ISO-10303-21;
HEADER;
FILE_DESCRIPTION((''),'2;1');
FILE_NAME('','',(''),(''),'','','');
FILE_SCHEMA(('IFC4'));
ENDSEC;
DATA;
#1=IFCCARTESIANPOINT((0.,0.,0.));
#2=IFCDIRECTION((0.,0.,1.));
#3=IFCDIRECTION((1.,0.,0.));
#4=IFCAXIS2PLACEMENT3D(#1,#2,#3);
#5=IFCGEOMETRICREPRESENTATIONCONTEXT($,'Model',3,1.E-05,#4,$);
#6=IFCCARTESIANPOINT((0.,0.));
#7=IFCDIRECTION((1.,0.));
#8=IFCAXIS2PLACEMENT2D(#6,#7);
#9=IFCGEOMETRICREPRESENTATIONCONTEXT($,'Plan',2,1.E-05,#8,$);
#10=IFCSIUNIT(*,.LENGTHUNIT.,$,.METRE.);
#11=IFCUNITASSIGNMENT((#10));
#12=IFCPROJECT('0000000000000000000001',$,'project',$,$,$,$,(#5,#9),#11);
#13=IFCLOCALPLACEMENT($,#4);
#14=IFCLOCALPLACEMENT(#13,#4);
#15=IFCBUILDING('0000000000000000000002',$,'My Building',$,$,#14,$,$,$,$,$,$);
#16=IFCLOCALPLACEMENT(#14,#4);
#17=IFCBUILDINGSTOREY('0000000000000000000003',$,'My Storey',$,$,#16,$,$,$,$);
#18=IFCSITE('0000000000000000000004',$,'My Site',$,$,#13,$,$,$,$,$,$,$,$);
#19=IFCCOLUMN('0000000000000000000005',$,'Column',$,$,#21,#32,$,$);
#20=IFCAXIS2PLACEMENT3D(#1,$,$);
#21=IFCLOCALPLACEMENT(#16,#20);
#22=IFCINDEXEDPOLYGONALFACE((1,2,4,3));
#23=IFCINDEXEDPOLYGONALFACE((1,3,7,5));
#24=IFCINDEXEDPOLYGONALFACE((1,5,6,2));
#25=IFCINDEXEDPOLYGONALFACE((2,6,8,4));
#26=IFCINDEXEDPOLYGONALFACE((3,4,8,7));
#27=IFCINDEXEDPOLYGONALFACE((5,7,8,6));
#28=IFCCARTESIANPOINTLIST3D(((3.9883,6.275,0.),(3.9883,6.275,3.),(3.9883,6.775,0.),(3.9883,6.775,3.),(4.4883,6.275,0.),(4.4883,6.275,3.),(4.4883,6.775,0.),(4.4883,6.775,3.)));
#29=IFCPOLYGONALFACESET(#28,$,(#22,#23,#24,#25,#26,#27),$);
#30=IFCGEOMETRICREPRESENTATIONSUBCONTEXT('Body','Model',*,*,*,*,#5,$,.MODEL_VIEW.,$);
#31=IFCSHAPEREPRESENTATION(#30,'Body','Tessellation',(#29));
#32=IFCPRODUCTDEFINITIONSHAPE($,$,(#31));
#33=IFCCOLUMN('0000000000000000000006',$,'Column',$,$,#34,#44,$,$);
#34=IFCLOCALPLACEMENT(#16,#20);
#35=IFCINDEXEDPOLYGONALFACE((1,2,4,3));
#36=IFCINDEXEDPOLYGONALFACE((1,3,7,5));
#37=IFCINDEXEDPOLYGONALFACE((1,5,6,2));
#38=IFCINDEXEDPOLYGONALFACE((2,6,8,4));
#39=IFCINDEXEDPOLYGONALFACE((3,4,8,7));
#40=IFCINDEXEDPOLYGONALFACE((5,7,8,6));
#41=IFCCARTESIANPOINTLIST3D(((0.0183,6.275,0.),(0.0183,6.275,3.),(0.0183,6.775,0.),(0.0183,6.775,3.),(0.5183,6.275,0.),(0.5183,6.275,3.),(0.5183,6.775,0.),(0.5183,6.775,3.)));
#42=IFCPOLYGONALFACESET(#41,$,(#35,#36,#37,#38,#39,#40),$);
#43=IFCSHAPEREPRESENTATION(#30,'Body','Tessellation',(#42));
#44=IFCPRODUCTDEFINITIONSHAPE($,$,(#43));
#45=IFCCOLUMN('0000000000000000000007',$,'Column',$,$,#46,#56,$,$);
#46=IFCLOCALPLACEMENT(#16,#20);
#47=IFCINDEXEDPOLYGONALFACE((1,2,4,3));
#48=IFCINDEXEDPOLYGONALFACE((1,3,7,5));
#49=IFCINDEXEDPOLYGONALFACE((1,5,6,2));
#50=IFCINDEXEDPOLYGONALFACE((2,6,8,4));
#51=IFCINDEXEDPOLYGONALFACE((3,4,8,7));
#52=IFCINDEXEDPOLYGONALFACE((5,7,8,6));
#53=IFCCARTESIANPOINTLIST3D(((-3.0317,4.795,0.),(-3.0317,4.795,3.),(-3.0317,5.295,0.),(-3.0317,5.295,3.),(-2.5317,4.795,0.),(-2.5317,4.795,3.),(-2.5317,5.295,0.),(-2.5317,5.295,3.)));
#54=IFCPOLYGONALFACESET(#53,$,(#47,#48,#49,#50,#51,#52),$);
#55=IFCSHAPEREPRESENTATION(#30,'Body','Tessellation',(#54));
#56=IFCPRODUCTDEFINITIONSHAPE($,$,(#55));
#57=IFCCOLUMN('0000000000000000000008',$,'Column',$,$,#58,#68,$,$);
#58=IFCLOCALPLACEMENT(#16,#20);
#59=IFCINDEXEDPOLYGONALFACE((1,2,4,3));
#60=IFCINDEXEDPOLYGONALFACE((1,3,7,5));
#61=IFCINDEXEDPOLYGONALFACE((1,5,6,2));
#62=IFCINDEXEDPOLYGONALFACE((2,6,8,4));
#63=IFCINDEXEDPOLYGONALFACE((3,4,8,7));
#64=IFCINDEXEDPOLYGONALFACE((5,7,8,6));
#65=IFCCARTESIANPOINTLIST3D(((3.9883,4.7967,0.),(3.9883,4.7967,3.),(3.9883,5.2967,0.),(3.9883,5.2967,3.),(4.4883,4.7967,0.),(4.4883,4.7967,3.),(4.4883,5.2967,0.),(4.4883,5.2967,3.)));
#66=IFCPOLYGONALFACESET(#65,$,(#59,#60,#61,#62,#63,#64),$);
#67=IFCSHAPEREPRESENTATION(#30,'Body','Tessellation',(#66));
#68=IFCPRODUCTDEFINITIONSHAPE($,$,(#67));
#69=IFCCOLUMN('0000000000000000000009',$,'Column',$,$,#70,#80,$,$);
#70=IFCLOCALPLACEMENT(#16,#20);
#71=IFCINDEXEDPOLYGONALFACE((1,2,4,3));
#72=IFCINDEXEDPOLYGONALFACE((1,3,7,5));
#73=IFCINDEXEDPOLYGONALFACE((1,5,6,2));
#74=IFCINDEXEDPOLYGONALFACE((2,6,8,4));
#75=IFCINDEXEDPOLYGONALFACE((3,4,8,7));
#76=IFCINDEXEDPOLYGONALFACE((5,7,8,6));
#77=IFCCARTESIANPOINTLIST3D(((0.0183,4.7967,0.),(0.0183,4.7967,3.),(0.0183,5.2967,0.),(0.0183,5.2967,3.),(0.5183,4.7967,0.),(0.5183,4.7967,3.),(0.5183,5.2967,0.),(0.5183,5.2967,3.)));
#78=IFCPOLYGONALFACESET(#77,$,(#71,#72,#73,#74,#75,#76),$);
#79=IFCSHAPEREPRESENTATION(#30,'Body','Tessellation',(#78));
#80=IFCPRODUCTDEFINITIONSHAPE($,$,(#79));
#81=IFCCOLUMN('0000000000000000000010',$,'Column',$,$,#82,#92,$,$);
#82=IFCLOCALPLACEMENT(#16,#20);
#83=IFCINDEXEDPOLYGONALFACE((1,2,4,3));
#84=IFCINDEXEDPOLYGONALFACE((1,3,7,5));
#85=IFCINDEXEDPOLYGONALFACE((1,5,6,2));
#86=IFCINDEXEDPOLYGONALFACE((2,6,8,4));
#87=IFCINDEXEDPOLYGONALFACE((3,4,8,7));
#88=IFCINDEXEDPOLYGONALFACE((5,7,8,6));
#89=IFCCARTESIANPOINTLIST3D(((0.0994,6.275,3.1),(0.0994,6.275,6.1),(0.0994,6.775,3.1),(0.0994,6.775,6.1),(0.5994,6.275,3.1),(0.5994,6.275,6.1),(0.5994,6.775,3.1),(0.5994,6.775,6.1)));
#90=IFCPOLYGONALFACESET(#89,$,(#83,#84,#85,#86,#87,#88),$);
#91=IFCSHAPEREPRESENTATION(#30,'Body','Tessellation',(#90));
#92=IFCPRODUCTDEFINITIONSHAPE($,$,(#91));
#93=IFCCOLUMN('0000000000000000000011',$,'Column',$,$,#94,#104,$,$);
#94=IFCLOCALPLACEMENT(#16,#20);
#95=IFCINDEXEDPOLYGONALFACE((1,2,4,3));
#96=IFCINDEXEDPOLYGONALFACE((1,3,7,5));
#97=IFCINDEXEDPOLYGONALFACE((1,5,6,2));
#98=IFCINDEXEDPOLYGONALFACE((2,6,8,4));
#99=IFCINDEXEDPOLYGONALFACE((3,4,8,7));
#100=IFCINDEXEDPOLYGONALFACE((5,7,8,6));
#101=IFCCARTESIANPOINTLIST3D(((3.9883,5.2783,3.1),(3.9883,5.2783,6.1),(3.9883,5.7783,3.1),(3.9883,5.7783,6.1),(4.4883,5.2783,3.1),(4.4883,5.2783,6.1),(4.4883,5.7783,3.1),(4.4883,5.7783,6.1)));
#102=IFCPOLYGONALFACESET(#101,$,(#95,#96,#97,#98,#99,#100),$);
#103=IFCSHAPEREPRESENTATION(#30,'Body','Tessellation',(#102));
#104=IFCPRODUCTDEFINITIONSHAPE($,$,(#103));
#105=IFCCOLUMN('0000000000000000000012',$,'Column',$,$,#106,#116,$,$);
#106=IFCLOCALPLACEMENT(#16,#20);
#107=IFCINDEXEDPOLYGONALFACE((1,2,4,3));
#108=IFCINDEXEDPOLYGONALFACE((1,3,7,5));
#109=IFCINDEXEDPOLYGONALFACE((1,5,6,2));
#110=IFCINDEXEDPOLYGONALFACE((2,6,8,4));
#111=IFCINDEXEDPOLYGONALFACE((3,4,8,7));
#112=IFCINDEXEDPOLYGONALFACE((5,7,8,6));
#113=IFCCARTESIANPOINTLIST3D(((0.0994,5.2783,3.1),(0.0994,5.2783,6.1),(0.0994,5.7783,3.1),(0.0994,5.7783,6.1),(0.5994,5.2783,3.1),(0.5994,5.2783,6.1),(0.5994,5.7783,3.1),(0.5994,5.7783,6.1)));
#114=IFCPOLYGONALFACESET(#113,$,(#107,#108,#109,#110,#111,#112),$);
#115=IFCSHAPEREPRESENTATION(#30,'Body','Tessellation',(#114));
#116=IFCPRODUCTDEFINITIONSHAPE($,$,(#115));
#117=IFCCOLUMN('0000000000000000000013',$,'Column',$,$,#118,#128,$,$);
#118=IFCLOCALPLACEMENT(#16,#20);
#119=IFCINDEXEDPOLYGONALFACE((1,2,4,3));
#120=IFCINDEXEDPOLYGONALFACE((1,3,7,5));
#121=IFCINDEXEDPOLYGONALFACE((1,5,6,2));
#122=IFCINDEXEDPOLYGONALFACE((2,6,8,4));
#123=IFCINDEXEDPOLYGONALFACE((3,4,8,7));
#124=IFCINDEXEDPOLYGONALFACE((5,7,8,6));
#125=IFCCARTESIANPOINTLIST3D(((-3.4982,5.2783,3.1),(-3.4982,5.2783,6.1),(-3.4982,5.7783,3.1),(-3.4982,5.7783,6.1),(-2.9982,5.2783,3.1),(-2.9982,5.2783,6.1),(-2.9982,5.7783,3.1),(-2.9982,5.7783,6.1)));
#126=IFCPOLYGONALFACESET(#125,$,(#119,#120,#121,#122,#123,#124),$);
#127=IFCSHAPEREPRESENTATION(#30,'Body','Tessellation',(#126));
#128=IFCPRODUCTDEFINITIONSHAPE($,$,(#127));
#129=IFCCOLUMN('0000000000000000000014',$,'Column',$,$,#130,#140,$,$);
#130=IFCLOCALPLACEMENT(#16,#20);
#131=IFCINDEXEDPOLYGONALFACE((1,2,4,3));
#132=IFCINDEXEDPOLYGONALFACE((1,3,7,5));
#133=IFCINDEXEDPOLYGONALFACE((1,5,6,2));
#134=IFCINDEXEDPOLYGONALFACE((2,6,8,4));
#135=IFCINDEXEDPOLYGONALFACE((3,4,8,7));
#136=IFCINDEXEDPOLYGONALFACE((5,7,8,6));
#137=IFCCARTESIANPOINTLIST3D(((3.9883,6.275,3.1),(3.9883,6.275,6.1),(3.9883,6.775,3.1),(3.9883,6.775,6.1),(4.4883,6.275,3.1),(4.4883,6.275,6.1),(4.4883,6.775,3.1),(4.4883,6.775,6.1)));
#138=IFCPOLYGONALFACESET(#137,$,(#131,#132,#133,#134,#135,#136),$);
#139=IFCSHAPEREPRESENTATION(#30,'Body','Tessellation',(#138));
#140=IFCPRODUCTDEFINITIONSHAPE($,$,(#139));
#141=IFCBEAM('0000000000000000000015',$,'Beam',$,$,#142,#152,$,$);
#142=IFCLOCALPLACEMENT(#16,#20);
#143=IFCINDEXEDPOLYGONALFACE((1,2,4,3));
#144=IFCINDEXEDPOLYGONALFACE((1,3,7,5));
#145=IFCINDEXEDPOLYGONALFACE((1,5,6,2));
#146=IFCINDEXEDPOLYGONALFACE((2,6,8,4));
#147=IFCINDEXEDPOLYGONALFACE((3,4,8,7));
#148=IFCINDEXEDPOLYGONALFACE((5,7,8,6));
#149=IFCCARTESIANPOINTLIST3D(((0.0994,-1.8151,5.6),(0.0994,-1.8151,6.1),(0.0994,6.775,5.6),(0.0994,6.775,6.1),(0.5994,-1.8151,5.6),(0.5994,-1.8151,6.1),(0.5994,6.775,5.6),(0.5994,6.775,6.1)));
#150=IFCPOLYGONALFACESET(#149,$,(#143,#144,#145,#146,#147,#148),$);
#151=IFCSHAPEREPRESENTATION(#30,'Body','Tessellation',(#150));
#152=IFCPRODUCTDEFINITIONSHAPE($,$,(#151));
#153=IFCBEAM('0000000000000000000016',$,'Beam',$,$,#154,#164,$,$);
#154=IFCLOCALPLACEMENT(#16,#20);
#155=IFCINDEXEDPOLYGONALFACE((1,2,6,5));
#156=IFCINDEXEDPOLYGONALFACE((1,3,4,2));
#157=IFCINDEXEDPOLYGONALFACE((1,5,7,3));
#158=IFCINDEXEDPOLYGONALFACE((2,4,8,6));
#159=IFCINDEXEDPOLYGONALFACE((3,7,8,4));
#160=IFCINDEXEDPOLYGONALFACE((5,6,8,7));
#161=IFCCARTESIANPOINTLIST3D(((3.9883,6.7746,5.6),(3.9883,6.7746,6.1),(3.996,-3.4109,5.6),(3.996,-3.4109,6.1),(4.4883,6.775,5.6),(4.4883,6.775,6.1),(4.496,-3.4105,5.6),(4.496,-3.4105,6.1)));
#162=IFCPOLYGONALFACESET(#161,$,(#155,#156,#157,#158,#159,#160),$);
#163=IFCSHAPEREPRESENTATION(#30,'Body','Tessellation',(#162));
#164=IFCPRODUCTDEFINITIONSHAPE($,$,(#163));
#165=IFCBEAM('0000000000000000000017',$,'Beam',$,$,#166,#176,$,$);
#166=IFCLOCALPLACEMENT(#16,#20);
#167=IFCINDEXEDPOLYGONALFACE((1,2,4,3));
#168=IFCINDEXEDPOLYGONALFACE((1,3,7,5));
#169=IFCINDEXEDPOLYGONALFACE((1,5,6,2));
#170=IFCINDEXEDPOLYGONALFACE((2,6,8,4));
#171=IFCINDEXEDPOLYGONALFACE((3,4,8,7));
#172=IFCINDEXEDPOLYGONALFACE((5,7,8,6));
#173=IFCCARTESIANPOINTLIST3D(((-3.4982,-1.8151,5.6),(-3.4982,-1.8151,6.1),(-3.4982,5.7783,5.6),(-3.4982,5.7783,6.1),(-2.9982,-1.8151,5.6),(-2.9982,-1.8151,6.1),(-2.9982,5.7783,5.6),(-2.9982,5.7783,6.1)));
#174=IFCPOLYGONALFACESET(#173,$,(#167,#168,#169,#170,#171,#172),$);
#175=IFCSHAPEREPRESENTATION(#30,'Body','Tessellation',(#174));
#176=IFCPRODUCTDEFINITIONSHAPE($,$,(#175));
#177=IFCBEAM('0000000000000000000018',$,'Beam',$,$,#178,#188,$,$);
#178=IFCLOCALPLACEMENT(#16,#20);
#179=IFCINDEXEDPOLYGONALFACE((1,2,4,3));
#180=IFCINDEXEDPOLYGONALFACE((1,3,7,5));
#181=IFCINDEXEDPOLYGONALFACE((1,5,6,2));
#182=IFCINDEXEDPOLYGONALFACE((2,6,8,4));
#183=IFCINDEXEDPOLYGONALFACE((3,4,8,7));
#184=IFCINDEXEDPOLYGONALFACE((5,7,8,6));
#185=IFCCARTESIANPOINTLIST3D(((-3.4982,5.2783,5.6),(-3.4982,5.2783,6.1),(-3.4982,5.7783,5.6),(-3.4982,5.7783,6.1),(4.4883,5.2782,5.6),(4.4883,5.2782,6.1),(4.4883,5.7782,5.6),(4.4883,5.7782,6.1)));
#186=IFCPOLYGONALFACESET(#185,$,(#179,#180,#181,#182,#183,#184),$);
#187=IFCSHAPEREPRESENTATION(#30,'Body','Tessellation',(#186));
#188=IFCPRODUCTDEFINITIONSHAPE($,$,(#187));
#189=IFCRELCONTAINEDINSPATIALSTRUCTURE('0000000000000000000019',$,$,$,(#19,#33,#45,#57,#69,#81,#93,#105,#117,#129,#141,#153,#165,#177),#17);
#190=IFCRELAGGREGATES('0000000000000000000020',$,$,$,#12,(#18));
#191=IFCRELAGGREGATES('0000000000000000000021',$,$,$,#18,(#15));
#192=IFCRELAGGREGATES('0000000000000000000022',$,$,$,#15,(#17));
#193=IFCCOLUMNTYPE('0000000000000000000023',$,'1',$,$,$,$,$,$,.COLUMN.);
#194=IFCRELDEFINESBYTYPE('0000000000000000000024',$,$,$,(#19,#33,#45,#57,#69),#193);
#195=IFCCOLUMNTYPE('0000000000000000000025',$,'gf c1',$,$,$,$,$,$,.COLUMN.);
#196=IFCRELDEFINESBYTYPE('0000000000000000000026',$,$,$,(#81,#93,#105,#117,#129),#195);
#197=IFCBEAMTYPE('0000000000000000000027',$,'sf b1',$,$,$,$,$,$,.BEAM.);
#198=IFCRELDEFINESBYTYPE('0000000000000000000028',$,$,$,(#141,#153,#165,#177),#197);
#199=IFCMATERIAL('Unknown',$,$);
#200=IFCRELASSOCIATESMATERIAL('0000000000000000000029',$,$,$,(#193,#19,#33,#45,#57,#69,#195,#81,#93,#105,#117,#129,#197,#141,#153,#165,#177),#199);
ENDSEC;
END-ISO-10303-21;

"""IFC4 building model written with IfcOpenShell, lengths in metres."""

from ifc_helpers import new_model, si_unit, frame, origin_with_axes, origin_2d_with_axis, place, context, subcontext, project, spatial, rectangle, extrude, material, material_profile, profile_set, profile_usage, type_object, element, save


model = new_model("IFC4")

# Units and contexts
model_context = context("Model", 3, precision=1e-05, world=origin_with_axes())
plan_context = context("Plan", 2, precision=1e-05, world=origin_2d_with_axis())
body_context = subcontext(model_context, "Body", "Model", "MODEL_VIEW")
ifc_project = project(units=[si_unit("LENGTHUNIT", "METRE")], contexts=[model_context, plan_context])

# Site, building, storey
site_placement = place(None, origin_with_axes())
site = spatial("IfcSite", under=ifc_project, at=site_placement, Name="My Site")
building_placement = place(site_placement, origin_with_axes())
building = spatial("IfcBuilding", under=site, at=building_placement, Name="My Building")
storey_placement = place(building_placement, origin_with_axes())
storey = spatial("IfcBuildingStorey", under=building, at=storey_placement, Name="My Storey")

# Columns
ifc_material = material(Name="Unknown")
ifc_material_profile_1 = material_profile(ifc_material, rectangle(XDim=0.5, YDim=0.5))
ifc_profile_set_1 = profile_set([ifc_material_profile_1])
ifc_profile_usage_1 = profile_usage(ifc_profile_set_1, cardinal=5)
column_type_1 = type_object("IfcColumnType", Name="1", PredefinedType="COLUMN", material=ifc_profile_set_1)
column_1_placement = place(storey_placement, frame((4.2383, 6.525, 0.0), z_axis=(0.0, 0.0, 1.0), x_axis=(1.0, 0.0, 0.0)))
element("IfcColumn", 1, at=column_1_placement, inside=storey, type_object=column_type_1, material=ifc_profile_usage_1, Name="Column", context=body_context, shape_type="SweptSolid", body=[
    extrude(rectangle(XDim=0.5, YDim=0.5), origin_with_axes(), (0.0, 0.0, 1.0), 3.0),
])
ifc_profile_usage_2 = profile_usage(ifc_profile_set_1, cardinal=5)
column_2_placement = place(storey_placement, frame((0.2683, 6.525, 0.0), z_axis=(0.0, 0.0, 1.0), x_axis=(1.0, 0.0, 0.0)))
element("IfcColumn", 2, at=column_2_placement, inside=storey, type_object=column_type_1, material=ifc_profile_usage_2, Name="Column", context=body_context, shape_type="SweptSolid", body=[
    extrude(rectangle(XDim=0.5, YDim=0.5), origin_with_axes(), (0.0, 0.0, 1.0), 3.0),
])
ifc_profile_usage_3 = profile_usage(ifc_profile_set_1, cardinal=5)
column_3_placement = place(storey_placement, frame((-2.7817, 5.045, 0.0), z_axis=(0.0, 0.0, 1.0), x_axis=(1.0, 0.0, 0.0)))
element("IfcColumn", 3, at=column_3_placement, inside=storey, type_object=column_type_1, material=ifc_profile_usage_3, Name="Column", context=body_context, shape_type="SweptSolid", body=[
    extrude(rectangle(XDim=0.5, YDim=0.5), origin_with_axes(), (0.0, 0.0, 1.0), 3.0),
])
ifc_profile_usage_4 = profile_usage(ifc_profile_set_1, cardinal=5)
column_4_placement = place(storey_placement, frame((4.2383, 5.0467, 0.0), z_axis=(0.0, 0.0, 1.0), x_axis=(1.0, 0.0, 0.0)))
element("IfcColumn", 4, at=column_4_placement, inside=storey, type_object=column_type_1, material=ifc_profile_usage_4, Name="Column", context=body_context, shape_type="SweptSolid", body=[
    extrude(rectangle(XDim=0.5, YDim=0.5), origin_with_axes(), (0.0, 0.0, 1.0), 3.0),
])
ifc_profile_usage_5 = profile_usage(ifc_profile_set_1, cardinal=5)
column_5_placement = place(storey_placement, frame((0.2683, 5.0467, 0.0), z_axis=(0.0, 0.0, 1.0), x_axis=(1.0, 0.0, 0.0)))
element("IfcColumn", 5, at=column_5_placement, inside=storey, type_object=column_type_1, material=ifc_profile_usage_5, Name="Column", context=body_context, shape_type="SweptSolid", body=[
    extrude(rectangle(XDim=0.5, YDim=0.5), origin_with_axes(), (0.0, 0.0, 1.0), 3.0),
])
ifc_material_profile_2 = material_profile(ifc_material, rectangle(XDim=0.5, YDim=0.5))
ifc_profile_set_2 = profile_set([ifc_material_profile_2])
ifc_profile_usage_6 = profile_usage(ifc_profile_set_2, cardinal=5)
column_type_2 = type_object("IfcColumnType", Name="gf c1", PredefinedType="COLUMN", material=ifc_profile_set_2)
column_6_placement = place(storey_placement, frame((0.3494, 6.525, 3.1), z_axis=(0.0, 0.0, 1.0), x_axis=(1.0, 0.0, 0.0)))
element("IfcColumn", 6, at=column_6_placement, inside=storey, type_object=column_type_2, material=ifc_profile_usage_6, Name="Column", context=body_context, shape_type="SweptSolid", body=[
    extrude(rectangle(XDim=0.5, YDim=0.5), origin_with_axes(), (0.0, 0.0, 1.0), 3.0),
])
ifc_profile_usage_7 = profile_usage(ifc_profile_set_2, cardinal=5)
column_7_placement = place(storey_placement, frame((4.2383, 5.5283, 3.1), z_axis=(0.0, 0.0, 1.0), x_axis=(1.0, 0.0, 0.0)))
element("IfcColumn", 7, at=column_7_placement, inside=storey, type_object=column_type_2, material=ifc_profile_usage_7, Name="Column", context=body_context, shape_type="SweptSolid", body=[
    extrude(rectangle(XDim=0.5, YDim=0.5), origin_with_axes(), (0.0, 0.0, 1.0), 3.0),
])
ifc_profile_usage_8 = profile_usage(ifc_profile_set_2, cardinal=5)
column_8_placement = place(storey_placement, frame((0.3494, 5.5283, 3.1), z_axis=(0.0, 0.0, 1.0), x_axis=(1.0, 0.0, 0.0)))
element("IfcColumn", 8, at=column_8_placement, inside=storey, type_object=column_type_2, material=ifc_profile_usage_8, Name="Column", context=body_context, shape_type="SweptSolid", body=[
    extrude(rectangle(XDim=0.5, YDim=0.5), origin_with_axes(), (0.0, 0.0, 1.0), 3.0),
])
ifc_profile_usage_9 = profile_usage(ifc_profile_set_2, cardinal=5)
column_9_placement = place(storey_placement, frame((-3.2482, 5.5283, 3.1), z_axis=(0.0, 0.0, 1.0), x_axis=(1.0, 0.0, 0.0)))
element("IfcColumn", 9, at=column_9_placement, inside=storey, type_object=column_type_2, material=ifc_profile_usage_9, Name="Column", context=body_context, shape_type="SweptSolid", body=[
    extrude(rectangle(XDim=0.5, YDim=0.5), origin_with_axes(), (0.0, 0.0, 1.0), 3.0),
])
ifc_profile_usage_10 = profile_usage(ifc_profile_set_2, cardinal=5)
column_10_placement = place(storey_placement, frame((4.2383, 6.525, 3.1), z_axis=(0.0, 0.0, 1.0), x_axis=(1.0, 0.0, 0.0)))
element("IfcColumn", 10, at=column_10_placement, inside=storey, type_object=column_type_2, material=ifc_profile_usage_10, Name="Column", context=body_context, shape_type="SweptSolid", body=[
    extrude(rectangle(XDim=0.5, YDim=0.5), origin_with_axes(), (0.0, 0.0, 1.0), 3.0),
])

# Beams
ifc_material_profile_3 = material_profile(ifc_material, rectangle(XDim=0.5, YDim=0.5))
ifc_profile_set_3 = profile_set([ifc_material_profile_3])
ifc_profile_usage_11 = profile_usage(ifc_profile_set_3, cardinal=7)
beam_type = type_object("IfcBeamType", Name="sf b1", PredefinedType="BEAM", material=ifc_profile_set_3)
beam_1_placement = place(storey_placement, frame((0.5994, 6.775, 6.1), z_axis=(0.0, -1.0, 0.0), x_axis=(1.0, 0.0, 0.0)))
element("IfcBeam", 11, at=beam_1_placement, inside=storey, type_object=beam_type, material=ifc_profile_usage_11, Name="Beam", context=body_context, shape_type="SweptSolid", body=[
    extrude(rectangle(XDim=0.5, YDim=0.5), frame((-0.25, -0.25, 0.0), z_axis=(0.0, 0.0, 1.0), x_axis=(1.0, 0.0, 0.0)), (0.0, 0.0, 1.0), 8.59),
])
ifc_profile_usage_12 = profile_usage(ifc_profile_set_3, cardinal=7)
beam_2_placement = place(storey_placement, frame((4.4883, 6.775, 6.1), z_axis=(0.000753, -1.0, 0.0), x_axis=(1.0, 0.000753, 0.0)))
element("IfcBeam", 12, at=beam_2_placement, inside=storey, type_object=beam_type, material=ifc_profile_usage_12, Name="Beam", context=body_context, shape_type="SweptSolid", body=[
    extrude(rectangle(XDim=0.5, YDim=0.5), frame((-0.25, -0.25, 0.0), z_axis=(0.0, 0.0, 1.0), x_axis=(1.0, 0.0, 0.0)), (0.0, 0.0, 1.0), 10.1855),
])
ifc_profile_usage_13 = profile_usage(ifc_profile_set_3, cardinal=7)
beam_3_placement = place(storey_placement, frame((-2.9982, 5.7783, 6.1), z_axis=(0.0, -1.0, 0.0), x_axis=(1.0, 0.0, 0.0)))
element("IfcBeam", 13, at=beam_3_placement, inside=storey, type_object=beam_type, material=ifc_profile_usage_13, Name="Beam", context=body_context, shape_type="SweptSolid", body=[
    extrude(rectangle(XDim=0.5, YDim=0.5), frame((-0.25, -0.25, 0.0), z_axis=(0.0, 0.0, 1.0), x_axis=(1.0, 0.0, 0.0)), (0.0, 0.0, 1.0), 7.5933),
])
ifc_profile_usage_14 = profile_usage(ifc_profile_set_3, cardinal=7)
beam_4_placement = place(storey_placement, frame((-3.4982, 5.7783, 6.1), z_axis=(1.0, -0.000001, 0.000001), x_axis=(0.000001, 1.0, 0.0)))
element("IfcBeam", 14, at=beam_4_placement, inside=storey, type_object=beam_type, material=ifc_profile_usage_14, Name="Beam", context=body_context, shape_type="SweptSolid", body=[
    extrude(rectangle(XDim=0.5, YDim=0.5), frame((-0.25, -0.25, 0.0), z_axis=(0.0, 0.0, 1.0), x_axis=(1.0, 0.0, 0.0)), (0.0, 0.0, 1.0), 7.9865),
])

save(model, "model.ifc")
